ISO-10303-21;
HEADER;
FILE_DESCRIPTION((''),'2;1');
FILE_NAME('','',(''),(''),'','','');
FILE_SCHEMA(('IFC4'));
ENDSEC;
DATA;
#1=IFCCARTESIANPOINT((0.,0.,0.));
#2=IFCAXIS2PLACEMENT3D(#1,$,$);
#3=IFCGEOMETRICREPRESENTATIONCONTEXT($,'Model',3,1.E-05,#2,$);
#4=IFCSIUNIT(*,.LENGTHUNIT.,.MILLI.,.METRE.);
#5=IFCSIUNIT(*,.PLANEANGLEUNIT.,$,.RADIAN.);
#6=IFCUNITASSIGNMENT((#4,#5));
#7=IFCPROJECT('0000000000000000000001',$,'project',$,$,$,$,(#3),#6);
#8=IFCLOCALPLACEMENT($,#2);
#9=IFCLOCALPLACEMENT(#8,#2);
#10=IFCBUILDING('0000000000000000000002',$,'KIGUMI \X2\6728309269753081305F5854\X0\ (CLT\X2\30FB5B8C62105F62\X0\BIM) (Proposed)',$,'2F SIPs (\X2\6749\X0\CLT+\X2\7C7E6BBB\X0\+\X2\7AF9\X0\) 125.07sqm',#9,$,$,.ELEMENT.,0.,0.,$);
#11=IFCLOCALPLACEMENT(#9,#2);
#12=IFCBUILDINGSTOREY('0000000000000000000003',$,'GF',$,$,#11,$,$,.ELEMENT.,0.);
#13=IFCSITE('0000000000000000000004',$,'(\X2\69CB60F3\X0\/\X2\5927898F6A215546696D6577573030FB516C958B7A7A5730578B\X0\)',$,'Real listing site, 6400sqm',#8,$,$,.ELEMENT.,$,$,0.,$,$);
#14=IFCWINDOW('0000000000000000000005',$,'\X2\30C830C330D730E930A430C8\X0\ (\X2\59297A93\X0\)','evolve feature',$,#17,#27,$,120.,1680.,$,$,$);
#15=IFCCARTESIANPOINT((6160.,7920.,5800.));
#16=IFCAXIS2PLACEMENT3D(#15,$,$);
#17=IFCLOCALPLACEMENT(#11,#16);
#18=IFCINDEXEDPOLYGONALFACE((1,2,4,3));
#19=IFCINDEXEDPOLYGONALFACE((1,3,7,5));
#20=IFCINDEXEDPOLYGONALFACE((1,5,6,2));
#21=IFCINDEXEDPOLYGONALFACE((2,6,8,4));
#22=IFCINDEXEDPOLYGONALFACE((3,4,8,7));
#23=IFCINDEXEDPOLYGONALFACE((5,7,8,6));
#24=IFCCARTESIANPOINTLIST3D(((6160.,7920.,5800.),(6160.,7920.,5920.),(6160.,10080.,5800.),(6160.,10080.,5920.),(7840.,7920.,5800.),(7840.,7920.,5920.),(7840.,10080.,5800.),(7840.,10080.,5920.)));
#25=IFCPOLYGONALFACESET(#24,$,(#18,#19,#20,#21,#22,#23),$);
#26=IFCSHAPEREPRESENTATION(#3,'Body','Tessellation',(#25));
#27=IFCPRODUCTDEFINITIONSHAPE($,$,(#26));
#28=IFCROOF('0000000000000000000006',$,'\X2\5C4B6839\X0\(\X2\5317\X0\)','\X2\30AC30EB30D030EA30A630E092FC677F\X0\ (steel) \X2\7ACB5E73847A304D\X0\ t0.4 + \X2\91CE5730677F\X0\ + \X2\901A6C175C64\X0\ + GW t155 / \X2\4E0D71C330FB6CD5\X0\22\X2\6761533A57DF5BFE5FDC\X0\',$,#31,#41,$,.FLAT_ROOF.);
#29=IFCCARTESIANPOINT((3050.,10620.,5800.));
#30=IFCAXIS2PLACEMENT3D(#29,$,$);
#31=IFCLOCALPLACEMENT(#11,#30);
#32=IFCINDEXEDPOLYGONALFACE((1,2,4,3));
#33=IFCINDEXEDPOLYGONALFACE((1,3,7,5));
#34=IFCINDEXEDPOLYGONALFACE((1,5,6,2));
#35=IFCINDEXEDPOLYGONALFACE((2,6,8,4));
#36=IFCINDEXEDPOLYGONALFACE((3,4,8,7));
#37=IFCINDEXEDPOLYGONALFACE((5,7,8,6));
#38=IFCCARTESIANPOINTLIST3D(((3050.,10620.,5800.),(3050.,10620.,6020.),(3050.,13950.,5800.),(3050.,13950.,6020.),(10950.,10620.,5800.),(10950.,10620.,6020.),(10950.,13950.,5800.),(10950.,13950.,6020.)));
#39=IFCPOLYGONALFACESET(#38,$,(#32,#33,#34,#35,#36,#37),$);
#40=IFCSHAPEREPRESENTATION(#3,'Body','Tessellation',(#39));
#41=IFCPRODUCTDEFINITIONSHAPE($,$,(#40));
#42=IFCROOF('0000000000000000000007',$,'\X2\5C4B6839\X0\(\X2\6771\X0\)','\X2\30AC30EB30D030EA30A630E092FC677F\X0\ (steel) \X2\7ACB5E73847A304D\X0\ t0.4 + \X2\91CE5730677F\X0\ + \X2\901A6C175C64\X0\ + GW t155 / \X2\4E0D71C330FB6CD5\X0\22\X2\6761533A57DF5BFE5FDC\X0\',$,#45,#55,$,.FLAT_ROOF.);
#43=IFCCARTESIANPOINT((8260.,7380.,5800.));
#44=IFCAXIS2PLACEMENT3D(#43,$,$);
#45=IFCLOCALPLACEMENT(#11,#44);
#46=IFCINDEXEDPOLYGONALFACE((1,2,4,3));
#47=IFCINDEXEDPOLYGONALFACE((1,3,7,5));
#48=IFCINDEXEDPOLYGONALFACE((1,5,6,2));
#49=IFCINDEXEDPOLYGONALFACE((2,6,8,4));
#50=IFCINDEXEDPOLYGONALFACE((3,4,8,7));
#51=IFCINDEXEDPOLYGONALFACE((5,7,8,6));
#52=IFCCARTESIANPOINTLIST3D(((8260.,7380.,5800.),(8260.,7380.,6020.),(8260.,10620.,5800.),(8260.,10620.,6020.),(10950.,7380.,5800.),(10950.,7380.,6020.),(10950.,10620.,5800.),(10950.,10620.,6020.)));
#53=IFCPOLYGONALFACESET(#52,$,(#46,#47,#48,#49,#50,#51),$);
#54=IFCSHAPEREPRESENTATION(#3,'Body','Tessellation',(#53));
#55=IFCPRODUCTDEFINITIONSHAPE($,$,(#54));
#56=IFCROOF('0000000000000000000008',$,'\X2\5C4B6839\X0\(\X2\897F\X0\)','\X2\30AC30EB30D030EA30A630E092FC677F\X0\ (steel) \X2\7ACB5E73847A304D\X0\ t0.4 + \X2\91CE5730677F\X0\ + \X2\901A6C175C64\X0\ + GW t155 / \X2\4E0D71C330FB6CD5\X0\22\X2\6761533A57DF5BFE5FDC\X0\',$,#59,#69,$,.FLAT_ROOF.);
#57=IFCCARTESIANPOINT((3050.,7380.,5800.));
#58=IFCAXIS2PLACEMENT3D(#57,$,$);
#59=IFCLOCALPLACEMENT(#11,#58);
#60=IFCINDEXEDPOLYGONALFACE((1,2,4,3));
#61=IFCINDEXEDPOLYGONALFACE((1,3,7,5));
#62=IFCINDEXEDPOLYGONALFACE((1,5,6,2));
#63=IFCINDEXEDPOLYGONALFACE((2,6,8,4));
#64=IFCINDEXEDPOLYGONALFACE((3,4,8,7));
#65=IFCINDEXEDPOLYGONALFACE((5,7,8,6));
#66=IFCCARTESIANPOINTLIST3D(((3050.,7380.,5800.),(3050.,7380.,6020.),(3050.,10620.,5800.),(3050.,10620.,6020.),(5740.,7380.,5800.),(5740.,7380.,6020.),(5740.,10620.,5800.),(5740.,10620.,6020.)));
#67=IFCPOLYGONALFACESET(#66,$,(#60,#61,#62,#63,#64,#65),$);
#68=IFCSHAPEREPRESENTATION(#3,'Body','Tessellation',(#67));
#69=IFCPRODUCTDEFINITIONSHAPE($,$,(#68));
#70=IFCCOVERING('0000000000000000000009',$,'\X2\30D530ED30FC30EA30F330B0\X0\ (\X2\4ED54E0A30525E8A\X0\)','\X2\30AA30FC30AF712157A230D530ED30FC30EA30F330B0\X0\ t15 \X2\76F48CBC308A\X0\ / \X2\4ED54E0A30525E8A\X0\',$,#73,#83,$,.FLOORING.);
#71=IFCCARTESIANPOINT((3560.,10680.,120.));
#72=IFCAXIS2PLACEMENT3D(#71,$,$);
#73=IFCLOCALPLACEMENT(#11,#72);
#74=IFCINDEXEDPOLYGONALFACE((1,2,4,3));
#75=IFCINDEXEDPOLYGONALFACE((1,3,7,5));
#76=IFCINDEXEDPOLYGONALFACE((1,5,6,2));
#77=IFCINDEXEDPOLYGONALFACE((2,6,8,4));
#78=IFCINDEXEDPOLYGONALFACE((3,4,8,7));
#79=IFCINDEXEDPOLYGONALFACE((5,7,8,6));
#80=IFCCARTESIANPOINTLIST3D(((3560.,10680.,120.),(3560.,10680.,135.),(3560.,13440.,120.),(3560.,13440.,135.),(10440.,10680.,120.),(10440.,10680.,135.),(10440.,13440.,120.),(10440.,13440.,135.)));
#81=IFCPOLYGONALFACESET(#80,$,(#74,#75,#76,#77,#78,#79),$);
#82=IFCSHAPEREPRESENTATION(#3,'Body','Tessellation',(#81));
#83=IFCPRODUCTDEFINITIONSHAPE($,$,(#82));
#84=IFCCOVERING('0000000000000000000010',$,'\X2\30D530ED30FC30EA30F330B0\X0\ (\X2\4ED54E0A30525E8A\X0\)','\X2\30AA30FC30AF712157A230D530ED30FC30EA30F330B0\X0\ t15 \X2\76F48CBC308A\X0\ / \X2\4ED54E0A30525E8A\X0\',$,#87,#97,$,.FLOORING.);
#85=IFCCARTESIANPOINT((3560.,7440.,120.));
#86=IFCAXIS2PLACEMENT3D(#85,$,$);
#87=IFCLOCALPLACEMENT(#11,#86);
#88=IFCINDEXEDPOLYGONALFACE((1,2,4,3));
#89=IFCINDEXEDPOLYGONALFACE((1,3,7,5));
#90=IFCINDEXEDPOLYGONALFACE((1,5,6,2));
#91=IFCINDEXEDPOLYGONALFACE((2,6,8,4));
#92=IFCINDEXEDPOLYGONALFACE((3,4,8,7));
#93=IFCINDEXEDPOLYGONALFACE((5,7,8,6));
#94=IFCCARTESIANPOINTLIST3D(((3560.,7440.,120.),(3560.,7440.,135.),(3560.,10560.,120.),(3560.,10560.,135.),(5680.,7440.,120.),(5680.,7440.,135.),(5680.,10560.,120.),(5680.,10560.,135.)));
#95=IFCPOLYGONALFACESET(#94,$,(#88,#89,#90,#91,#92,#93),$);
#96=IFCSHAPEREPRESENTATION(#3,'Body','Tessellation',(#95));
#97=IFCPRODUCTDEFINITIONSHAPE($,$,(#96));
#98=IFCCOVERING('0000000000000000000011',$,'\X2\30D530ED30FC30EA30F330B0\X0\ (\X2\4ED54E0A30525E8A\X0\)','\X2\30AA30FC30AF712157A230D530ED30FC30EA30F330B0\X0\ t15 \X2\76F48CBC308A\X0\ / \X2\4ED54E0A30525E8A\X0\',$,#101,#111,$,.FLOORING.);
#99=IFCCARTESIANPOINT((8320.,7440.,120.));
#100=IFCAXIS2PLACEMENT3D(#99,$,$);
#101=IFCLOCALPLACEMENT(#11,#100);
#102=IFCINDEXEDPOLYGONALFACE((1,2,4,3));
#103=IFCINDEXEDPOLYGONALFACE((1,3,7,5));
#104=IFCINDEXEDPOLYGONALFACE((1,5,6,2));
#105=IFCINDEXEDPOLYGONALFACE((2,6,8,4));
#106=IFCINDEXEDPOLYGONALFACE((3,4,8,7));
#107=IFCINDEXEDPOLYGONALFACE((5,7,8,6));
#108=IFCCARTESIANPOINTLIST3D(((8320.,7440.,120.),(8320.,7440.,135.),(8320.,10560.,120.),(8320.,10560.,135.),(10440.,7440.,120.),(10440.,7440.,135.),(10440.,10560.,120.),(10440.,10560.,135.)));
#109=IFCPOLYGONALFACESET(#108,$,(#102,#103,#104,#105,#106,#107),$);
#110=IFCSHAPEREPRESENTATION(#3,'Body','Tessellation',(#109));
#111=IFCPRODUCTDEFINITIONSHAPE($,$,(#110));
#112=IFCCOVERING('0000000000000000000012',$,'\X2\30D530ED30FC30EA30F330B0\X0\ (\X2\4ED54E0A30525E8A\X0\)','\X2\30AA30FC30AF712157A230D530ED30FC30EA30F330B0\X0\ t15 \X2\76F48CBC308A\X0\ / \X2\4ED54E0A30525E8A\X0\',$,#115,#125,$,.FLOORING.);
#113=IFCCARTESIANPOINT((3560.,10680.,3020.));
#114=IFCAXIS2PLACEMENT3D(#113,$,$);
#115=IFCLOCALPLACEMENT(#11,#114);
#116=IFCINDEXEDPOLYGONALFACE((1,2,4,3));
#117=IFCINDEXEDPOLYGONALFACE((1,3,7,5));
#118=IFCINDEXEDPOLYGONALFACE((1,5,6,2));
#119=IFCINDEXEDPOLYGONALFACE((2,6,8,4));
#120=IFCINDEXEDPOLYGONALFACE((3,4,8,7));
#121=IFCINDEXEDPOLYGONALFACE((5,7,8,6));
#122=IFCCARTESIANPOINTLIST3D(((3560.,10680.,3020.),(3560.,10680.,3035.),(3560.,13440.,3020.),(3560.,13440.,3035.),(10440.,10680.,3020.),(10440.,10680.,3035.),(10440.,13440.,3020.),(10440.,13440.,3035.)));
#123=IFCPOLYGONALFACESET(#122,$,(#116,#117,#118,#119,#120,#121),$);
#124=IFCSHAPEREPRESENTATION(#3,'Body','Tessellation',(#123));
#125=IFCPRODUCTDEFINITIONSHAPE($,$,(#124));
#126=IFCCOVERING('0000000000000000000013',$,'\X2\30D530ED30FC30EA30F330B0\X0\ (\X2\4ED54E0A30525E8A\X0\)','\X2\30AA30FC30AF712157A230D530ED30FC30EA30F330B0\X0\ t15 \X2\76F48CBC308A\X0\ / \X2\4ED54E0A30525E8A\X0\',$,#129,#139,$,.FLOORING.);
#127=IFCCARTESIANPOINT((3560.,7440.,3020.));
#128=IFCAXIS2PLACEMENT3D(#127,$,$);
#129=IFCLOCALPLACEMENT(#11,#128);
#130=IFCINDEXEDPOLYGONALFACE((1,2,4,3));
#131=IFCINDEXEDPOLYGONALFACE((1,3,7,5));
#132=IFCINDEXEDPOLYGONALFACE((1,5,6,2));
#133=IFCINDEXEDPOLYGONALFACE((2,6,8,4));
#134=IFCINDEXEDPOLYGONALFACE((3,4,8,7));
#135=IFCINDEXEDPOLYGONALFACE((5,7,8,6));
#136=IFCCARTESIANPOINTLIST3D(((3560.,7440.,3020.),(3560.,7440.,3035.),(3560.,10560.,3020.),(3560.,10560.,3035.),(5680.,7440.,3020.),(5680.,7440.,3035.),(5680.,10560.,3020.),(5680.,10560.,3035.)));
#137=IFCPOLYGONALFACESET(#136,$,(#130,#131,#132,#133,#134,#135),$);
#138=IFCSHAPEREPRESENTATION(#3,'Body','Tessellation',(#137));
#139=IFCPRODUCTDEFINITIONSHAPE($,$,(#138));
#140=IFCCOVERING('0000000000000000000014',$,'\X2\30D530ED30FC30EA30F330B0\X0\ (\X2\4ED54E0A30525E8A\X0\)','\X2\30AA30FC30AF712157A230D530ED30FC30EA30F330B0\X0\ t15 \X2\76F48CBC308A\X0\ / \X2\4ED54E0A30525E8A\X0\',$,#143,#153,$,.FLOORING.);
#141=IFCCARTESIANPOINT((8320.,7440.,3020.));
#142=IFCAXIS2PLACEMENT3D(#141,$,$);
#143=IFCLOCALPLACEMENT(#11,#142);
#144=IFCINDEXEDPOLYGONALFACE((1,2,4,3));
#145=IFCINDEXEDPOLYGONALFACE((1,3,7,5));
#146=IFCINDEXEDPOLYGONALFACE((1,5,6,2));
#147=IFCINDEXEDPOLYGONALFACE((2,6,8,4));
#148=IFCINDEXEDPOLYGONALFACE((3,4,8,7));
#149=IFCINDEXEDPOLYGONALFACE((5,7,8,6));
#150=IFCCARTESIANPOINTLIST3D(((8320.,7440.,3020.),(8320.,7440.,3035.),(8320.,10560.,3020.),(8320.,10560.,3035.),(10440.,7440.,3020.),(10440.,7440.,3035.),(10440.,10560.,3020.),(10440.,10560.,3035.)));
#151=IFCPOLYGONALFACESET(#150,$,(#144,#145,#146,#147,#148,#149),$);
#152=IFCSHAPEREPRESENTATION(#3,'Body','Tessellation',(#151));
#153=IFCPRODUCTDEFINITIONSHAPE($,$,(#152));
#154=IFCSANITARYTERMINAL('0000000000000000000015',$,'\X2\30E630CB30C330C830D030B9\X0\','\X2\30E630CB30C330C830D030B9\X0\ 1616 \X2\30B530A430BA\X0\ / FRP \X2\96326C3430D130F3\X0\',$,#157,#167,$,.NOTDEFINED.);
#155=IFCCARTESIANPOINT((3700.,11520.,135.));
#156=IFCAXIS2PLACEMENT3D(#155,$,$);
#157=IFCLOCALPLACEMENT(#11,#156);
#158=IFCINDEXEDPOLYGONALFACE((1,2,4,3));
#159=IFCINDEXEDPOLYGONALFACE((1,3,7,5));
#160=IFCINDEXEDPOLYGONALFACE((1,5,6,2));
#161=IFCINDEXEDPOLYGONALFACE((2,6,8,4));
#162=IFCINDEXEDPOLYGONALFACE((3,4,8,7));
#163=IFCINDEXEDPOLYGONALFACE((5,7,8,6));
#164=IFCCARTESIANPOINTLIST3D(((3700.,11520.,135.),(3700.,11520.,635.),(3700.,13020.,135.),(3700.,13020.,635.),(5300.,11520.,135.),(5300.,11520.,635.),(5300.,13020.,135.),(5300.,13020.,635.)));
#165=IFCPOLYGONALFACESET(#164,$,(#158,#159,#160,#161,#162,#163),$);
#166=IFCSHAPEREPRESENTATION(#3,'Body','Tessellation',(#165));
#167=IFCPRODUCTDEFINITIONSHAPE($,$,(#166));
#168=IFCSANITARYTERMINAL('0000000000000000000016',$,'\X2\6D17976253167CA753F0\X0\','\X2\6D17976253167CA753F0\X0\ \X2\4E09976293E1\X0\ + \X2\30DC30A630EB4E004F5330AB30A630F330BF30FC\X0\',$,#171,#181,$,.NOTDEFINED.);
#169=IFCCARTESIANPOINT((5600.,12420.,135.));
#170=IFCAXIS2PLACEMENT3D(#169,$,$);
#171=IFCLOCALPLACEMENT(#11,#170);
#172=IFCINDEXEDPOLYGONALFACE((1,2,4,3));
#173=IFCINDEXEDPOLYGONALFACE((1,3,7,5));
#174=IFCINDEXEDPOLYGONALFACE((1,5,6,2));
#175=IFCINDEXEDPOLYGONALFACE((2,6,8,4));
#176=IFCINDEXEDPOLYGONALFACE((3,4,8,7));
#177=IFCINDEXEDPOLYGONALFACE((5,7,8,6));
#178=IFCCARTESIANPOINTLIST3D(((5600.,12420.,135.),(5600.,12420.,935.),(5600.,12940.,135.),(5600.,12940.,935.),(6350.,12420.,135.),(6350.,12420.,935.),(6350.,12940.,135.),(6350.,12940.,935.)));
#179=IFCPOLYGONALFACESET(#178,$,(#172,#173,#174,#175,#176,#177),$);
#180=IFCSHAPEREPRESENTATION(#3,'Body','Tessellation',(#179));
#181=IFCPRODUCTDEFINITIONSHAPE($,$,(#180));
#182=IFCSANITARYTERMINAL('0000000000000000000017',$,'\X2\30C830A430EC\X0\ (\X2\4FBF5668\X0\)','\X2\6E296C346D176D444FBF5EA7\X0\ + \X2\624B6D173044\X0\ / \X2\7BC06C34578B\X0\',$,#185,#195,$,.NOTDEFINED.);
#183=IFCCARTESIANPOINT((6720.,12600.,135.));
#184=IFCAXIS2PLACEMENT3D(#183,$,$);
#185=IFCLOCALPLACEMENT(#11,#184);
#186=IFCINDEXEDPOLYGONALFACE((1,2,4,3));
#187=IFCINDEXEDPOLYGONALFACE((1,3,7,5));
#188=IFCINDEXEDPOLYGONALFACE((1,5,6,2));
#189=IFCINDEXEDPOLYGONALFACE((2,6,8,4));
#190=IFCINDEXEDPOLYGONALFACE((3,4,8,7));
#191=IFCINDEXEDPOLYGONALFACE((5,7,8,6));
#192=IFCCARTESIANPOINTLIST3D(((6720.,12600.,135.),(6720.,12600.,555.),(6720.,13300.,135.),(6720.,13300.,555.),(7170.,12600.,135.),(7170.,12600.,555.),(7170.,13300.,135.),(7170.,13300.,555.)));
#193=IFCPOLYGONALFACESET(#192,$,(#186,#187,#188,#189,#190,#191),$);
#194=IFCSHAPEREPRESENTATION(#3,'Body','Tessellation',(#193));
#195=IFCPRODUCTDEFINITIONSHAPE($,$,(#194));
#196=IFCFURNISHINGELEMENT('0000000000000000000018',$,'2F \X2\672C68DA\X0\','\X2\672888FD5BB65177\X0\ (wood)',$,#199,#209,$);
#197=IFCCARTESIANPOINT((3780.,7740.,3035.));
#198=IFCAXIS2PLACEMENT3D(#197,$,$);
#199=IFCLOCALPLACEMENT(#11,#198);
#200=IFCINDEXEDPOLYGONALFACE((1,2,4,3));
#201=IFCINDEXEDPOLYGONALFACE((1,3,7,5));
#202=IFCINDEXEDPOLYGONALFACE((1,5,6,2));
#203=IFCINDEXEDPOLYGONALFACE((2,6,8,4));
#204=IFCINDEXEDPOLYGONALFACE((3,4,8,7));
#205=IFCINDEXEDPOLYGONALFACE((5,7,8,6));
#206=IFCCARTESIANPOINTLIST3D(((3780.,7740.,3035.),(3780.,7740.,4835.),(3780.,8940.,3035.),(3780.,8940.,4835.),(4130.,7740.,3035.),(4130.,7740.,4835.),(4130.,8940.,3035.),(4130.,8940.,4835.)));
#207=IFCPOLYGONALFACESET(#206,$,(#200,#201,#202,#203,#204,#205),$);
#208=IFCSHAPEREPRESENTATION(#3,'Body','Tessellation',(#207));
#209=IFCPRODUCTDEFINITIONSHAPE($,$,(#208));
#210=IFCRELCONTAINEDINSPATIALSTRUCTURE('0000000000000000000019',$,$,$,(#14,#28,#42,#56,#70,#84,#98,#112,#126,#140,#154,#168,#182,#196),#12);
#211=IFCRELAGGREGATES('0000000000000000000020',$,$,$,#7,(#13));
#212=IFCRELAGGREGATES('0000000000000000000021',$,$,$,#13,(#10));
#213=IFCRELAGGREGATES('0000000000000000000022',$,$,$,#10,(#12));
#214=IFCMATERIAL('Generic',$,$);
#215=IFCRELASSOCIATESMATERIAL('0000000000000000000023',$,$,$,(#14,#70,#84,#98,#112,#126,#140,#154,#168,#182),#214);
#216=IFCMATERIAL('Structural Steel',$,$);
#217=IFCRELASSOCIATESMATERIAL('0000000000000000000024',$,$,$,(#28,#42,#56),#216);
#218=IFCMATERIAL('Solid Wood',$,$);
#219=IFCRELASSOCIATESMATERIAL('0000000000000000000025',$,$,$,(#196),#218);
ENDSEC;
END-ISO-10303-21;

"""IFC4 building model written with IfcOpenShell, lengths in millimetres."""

from ifc_helpers import new_model, si_unit, frame, frame_2d, origin, place, context, project, spatial, rectangle, extrude, material, element, save


model = new_model("IFC4")

# Units and contexts
model_context = context("Model", 3, precision=1e-05, world=origin())
ifc_project = project(units=[si_unit("LENGTHUNIT", "METRE", prefix="MILLI"), si_unit("PLANEANGLEUNIT", "RADIAN")], contexts=[model_context])

# Site, building, storey
site_placement = place(None, origin())
site = spatial("IfcSite", under=ifc_project, at=site_placement, Name="(構想/大規模商業敷地・公開空地型)", ObjectType="Real listing site, 6400sqm", CompositionType="ELEMENT", RefElevation=0.0)
building_placement = place(site_placement, origin())
building = spatial("IfcBuilding", under=site, at=building_placement, Name="KIGUMI 木を極めた塔 (CLT・完成形BIM) (Proposed)", ObjectType="2F SIPs (杉CLT+籾殻+竹) 125.07sqm", CompositionType="ELEMENT", ElevationOfRefHeight=0.0, ElevationOfTerrain=0.0)
storey_placement = place(building_placement, origin())
storey = spatial("IfcBuildingStorey", under=building, at=storey_placement, Name="GF", CompositionType="ELEMENT", Elevation=0.0)

# Shared definitions
ifc_material_1 = material(Name="Solid Wood")

# Window
ifc_material_2 = material(Name="Generic")
window_1_placement = place(storey_placement, frame((6160.0, 7920.0, 5800.0)))
element("IfcWindow", 1, at=window_1_placement, inside=storey, material=ifc_material_2, Name="トップライト (天窓)", Description="evolve feature", OverallHeight=120.0, OverallWidth=1680.0, context=model_context, shape_type="SweptSolid", body=[
    extrude(rectangle(XDim=1680.0, YDim=2160.0, at=frame_2d((840.0, 1080.0))), frame((6160.0, 7920.0, 5800.0)), (0.0, 0.0, 1.0), 120.0),
])

# Roofs
ifc_material_3 = material(Name="Structural Steel")
roof_1_placement = place(storey_placement, frame((3050.0, 10620.0, 5800.0)))
element("IfcRoof", 2, at=roof_1_placement, inside=storey, material=ifc_material_3, Name="屋根(北)", Description="ガルバリウム鋼板 (steel) 立平葺き t0.4 + 野地板 + 通気層 + GW t155 / 不燃・法22条区域対応", PredefinedType="FLAT_ROOF", context=model_context, shape_type="SweptSolid", body=[
    extrude(rectangle(XDim=7900.0, YDim=3330.0, at=frame_2d((3950.0, 1665.0))), frame((3050.0, 10620.0, 5800.0)), (0.0, 0.0, 1.0), 220.0),
])
roof_2_placement = place(storey_placement, frame((8260.0, 7380.0, 5800.0)))
element("IfcRoof", 3, at=roof_2_placement, inside=storey, material=ifc_material_3, Name="屋根(東)", Description="ガルバリウム鋼板 (steel) 立平葺き t0.4 + 野地板 + 通気層 + GW t155 / 不燃・法22条区域対応", PredefinedType="FLAT_ROOF", context=model_context, shape_type="SweptSolid", body=[
    extrude(rectangle(XDim=2690.0, YDim=3240.0, at=frame_2d((1345.0, 1620.0))), frame((8260.0, 7380.0, 5800.0)), (0.0, 0.0, 1.0), 220.0),
])
roof_3_placement = place(storey_placement, frame((3050.0, 7380.0, 5800.0)))
element("IfcRoof", 4, at=roof_3_placement, inside=storey, material=ifc_material_3, Name="屋根(西)", Description="ガルバリウム鋼板 (steel) 立平葺き t0.4 + 野地板 + 通気層 + GW t155 / 不燃・法22条区域対応", PredefinedType="FLAT_ROOF", context=model_context, shape_type="SweptSolid", body=[
    extrude(rectangle(XDim=2690.0, YDim=3240.0, at=frame_2d((1345.0, 1620.0))), frame((3050.0, 7380.0, 5800.0)), (0.0, 0.0, 1.0), 220.0),
])

# Coverings
covering_1_placement = place(storey_placement, frame((3560.0, 10680.0, 120.0)))
element("IfcCovering", 5, at=covering_1_placement, inside=storey, material=ifc_material_2, Name="フローリング (仕上げ床)", Description="オーク無垢フローリング t15 直貼り / 仕上げ床", PredefinedType="FLOORING", context=model_context, shape_type="SweptSolid", body=[
    extrude(rectangle(XDim=6880.0, YDim=2760.0, at=frame_2d((3440.0, 1380.0))), frame((3560.0, 10680.0, 120.0)), (0.0, 0.0, 1.0), 15.0),
])
covering_2_placement = place(storey_placement, frame((3560.0, 7440.0, 120.0)))
element("IfcCovering", 6, at=covering_2_placement, inside=storey, material=ifc_material_2, Name="フローリング (仕上げ床)", Description="オーク無垢フローリング t15 直貼り / 仕上げ床", PredefinedType="FLOORING", context=model_context, shape_type="SweptSolid", body=[
    extrude(rectangle(XDim=2120.0, YDim=3120.0, at=frame_2d((1060.0, 1560.0))), frame((3560.0, 7440.0, 120.0)), (0.0, 0.0, 1.0), 15.0),
])
covering_3_placement = place(storey_placement, frame((8320.0, 7440.0, 120.0)))
element("IfcCovering", 7, at=covering_3_placement, inside=storey, material=ifc_material_2, Name="フローリング (仕上げ床)", Description="オーク無垢フローリング t15 直貼り / 仕上げ床", PredefinedType="FLOORING", context=model_context, shape_type="SweptSolid", body=[
    extrude(rectangle(XDim=2120.0, YDim=3120.0, at=frame_2d((1060.0, 1560.0))), frame((8320.0, 7440.0, 120.0)), (0.0, 0.0, 1.0), 15.0),
])
covering_4_placement = place(storey_placement, frame((3560.0, 10680.0, 3020.0)))
element("IfcCovering", 8, at=covering_4_placement, inside=storey, material=ifc_material_2, Name="フローリング (仕上げ床)", Description="オーク無垢フローリング t15 直貼り / 仕上げ床", PredefinedType="FLOORING", context=model_context, shape_type="SweptSolid", body=[
    extrude(rectangle(XDim=6880.0, YDim=2760.0, at=frame_2d((3440.0, 1380.0))), frame((3560.0, 10680.0, 3020.0)), (0.0, 0.0, 1.0), 15.0),
])
covering_5_placement = place(storey_placement, frame((3560.0, 7440.0, 3020.0)))
element("IfcCovering", 9, at=covering_5_placement, inside=storey, material=ifc_material_2, Name="フローリング (仕上げ床)", Description="オーク無垢フローリング t15 直貼り / 仕上げ床", PredefinedType="FLOORING", context=model_context, shape_type="SweptSolid", body=[
    extrude(rectangle(XDim=2120.0, YDim=3120.0, at=frame_2d((1060.0, 1560.0))), frame((3560.0, 7440.0, 3020.0)), (0.0, 0.0, 1.0), 15.0),
])
covering_6_placement = place(storey_placement, frame((8320.0, 7440.0, 3020.0)))
element("IfcCovering", 10, at=covering_6_placement, inside=storey, material=ifc_material_2, Name="フローリング (仕上げ床)", Description="オーク無垢フローリング t15 直貼り / 仕上げ床", PredefinedType="FLOORING", context=model_context, shape_type="SweptSolid", body=[
    extrude(rectangle(XDim=2120.0, YDim=3120.0, at=frame_2d((1060.0, 1560.0))), frame((8320.0, 7440.0, 3020.0)), (0.0, 0.0, 1.0), 15.0),
])

# Sanitary terminals
sanitary_terminal_1_placement = place(storey_placement, frame((3700.0, 11520.0, 135.0)))
element("IfcSanitaryTerminal", 11, at=sanitary_terminal_1_placement, inside=storey, material=ifc_material_2, Name="ユニットバス", Description="ユニットバス 1616 サイズ / FRP 防水パン", PredefinedType="NOTDEFINED", context=model_context, shape_type="SweptSolid", body=[
    extrude(rectangle(XDim=1600.0, YDim=1500.0, at=frame_2d((800.0, 750.0))), frame((3700.0, 11520.0, 135.0)), (0.0, 0.0, 1.0), 500.0),
])
sanitary_terminal_2_placement = place(storey_placement, frame((5600.0, 12420.0, 135.0)))
element("IfcSanitaryTerminal", 12, at=sanitary_terminal_2_placement, inside=storey, material=ifc_material_2, Name="洗面化粧台", Description="洗面化粧台 三面鏡 + ボウル一体カウンター", PredefinedType="NOTDEFINED", context=model_context, shape_type="SweptSolid", body=[
    extrude(rectangle(XDim=750.0, YDim=520.0, at=frame_2d((375.0, 260.0))), frame((5600.0, 12420.0, 135.0)), (0.0, 0.0, 1.0), 800.0),
])
sanitary_terminal_3_placement = place(storey_placement, frame((6720.0, 12600.0, 135.0)))
element("IfcSanitaryTerminal", 13, at=sanitary_terminal_3_placement, inside=storey, material=ifc_material_2, Name="トイレ (便器)", Description="温水洗浄便座 + 手洗い / 節水型", PredefinedType="NOTDEFINED", context=model_context, shape_type="SweptSolid", body=[
    extrude(rectangle(XDim=450.0, YDim=700.0, at=frame_2d((225.0, 350.0))), frame((6720.0, 12600.0, 135.0)), (0.0, 0.0, 1.0), 420.0),
])

# Furnishing element
furnishing_placement = place(storey_placement, frame((3780.0, 7740.0, 3035.0)))
element("IfcFurnishingElement", 14, at=furnishing_placement, inside=storey, material=ifc_material_1, Name="2F 本棚", Description="木製家具 (wood)", context=model_context, shape_type="SweptSolid", body=[
    extrude(rectangle(XDim=350.0, YDim=1200.0, at=frame_2d((175.0, 600.0))), frame((3780.0, 7740.0, 3035.0)), (0.0, 0.0, 1.0), 1800.0),
])

save(model, "model.ifc")
